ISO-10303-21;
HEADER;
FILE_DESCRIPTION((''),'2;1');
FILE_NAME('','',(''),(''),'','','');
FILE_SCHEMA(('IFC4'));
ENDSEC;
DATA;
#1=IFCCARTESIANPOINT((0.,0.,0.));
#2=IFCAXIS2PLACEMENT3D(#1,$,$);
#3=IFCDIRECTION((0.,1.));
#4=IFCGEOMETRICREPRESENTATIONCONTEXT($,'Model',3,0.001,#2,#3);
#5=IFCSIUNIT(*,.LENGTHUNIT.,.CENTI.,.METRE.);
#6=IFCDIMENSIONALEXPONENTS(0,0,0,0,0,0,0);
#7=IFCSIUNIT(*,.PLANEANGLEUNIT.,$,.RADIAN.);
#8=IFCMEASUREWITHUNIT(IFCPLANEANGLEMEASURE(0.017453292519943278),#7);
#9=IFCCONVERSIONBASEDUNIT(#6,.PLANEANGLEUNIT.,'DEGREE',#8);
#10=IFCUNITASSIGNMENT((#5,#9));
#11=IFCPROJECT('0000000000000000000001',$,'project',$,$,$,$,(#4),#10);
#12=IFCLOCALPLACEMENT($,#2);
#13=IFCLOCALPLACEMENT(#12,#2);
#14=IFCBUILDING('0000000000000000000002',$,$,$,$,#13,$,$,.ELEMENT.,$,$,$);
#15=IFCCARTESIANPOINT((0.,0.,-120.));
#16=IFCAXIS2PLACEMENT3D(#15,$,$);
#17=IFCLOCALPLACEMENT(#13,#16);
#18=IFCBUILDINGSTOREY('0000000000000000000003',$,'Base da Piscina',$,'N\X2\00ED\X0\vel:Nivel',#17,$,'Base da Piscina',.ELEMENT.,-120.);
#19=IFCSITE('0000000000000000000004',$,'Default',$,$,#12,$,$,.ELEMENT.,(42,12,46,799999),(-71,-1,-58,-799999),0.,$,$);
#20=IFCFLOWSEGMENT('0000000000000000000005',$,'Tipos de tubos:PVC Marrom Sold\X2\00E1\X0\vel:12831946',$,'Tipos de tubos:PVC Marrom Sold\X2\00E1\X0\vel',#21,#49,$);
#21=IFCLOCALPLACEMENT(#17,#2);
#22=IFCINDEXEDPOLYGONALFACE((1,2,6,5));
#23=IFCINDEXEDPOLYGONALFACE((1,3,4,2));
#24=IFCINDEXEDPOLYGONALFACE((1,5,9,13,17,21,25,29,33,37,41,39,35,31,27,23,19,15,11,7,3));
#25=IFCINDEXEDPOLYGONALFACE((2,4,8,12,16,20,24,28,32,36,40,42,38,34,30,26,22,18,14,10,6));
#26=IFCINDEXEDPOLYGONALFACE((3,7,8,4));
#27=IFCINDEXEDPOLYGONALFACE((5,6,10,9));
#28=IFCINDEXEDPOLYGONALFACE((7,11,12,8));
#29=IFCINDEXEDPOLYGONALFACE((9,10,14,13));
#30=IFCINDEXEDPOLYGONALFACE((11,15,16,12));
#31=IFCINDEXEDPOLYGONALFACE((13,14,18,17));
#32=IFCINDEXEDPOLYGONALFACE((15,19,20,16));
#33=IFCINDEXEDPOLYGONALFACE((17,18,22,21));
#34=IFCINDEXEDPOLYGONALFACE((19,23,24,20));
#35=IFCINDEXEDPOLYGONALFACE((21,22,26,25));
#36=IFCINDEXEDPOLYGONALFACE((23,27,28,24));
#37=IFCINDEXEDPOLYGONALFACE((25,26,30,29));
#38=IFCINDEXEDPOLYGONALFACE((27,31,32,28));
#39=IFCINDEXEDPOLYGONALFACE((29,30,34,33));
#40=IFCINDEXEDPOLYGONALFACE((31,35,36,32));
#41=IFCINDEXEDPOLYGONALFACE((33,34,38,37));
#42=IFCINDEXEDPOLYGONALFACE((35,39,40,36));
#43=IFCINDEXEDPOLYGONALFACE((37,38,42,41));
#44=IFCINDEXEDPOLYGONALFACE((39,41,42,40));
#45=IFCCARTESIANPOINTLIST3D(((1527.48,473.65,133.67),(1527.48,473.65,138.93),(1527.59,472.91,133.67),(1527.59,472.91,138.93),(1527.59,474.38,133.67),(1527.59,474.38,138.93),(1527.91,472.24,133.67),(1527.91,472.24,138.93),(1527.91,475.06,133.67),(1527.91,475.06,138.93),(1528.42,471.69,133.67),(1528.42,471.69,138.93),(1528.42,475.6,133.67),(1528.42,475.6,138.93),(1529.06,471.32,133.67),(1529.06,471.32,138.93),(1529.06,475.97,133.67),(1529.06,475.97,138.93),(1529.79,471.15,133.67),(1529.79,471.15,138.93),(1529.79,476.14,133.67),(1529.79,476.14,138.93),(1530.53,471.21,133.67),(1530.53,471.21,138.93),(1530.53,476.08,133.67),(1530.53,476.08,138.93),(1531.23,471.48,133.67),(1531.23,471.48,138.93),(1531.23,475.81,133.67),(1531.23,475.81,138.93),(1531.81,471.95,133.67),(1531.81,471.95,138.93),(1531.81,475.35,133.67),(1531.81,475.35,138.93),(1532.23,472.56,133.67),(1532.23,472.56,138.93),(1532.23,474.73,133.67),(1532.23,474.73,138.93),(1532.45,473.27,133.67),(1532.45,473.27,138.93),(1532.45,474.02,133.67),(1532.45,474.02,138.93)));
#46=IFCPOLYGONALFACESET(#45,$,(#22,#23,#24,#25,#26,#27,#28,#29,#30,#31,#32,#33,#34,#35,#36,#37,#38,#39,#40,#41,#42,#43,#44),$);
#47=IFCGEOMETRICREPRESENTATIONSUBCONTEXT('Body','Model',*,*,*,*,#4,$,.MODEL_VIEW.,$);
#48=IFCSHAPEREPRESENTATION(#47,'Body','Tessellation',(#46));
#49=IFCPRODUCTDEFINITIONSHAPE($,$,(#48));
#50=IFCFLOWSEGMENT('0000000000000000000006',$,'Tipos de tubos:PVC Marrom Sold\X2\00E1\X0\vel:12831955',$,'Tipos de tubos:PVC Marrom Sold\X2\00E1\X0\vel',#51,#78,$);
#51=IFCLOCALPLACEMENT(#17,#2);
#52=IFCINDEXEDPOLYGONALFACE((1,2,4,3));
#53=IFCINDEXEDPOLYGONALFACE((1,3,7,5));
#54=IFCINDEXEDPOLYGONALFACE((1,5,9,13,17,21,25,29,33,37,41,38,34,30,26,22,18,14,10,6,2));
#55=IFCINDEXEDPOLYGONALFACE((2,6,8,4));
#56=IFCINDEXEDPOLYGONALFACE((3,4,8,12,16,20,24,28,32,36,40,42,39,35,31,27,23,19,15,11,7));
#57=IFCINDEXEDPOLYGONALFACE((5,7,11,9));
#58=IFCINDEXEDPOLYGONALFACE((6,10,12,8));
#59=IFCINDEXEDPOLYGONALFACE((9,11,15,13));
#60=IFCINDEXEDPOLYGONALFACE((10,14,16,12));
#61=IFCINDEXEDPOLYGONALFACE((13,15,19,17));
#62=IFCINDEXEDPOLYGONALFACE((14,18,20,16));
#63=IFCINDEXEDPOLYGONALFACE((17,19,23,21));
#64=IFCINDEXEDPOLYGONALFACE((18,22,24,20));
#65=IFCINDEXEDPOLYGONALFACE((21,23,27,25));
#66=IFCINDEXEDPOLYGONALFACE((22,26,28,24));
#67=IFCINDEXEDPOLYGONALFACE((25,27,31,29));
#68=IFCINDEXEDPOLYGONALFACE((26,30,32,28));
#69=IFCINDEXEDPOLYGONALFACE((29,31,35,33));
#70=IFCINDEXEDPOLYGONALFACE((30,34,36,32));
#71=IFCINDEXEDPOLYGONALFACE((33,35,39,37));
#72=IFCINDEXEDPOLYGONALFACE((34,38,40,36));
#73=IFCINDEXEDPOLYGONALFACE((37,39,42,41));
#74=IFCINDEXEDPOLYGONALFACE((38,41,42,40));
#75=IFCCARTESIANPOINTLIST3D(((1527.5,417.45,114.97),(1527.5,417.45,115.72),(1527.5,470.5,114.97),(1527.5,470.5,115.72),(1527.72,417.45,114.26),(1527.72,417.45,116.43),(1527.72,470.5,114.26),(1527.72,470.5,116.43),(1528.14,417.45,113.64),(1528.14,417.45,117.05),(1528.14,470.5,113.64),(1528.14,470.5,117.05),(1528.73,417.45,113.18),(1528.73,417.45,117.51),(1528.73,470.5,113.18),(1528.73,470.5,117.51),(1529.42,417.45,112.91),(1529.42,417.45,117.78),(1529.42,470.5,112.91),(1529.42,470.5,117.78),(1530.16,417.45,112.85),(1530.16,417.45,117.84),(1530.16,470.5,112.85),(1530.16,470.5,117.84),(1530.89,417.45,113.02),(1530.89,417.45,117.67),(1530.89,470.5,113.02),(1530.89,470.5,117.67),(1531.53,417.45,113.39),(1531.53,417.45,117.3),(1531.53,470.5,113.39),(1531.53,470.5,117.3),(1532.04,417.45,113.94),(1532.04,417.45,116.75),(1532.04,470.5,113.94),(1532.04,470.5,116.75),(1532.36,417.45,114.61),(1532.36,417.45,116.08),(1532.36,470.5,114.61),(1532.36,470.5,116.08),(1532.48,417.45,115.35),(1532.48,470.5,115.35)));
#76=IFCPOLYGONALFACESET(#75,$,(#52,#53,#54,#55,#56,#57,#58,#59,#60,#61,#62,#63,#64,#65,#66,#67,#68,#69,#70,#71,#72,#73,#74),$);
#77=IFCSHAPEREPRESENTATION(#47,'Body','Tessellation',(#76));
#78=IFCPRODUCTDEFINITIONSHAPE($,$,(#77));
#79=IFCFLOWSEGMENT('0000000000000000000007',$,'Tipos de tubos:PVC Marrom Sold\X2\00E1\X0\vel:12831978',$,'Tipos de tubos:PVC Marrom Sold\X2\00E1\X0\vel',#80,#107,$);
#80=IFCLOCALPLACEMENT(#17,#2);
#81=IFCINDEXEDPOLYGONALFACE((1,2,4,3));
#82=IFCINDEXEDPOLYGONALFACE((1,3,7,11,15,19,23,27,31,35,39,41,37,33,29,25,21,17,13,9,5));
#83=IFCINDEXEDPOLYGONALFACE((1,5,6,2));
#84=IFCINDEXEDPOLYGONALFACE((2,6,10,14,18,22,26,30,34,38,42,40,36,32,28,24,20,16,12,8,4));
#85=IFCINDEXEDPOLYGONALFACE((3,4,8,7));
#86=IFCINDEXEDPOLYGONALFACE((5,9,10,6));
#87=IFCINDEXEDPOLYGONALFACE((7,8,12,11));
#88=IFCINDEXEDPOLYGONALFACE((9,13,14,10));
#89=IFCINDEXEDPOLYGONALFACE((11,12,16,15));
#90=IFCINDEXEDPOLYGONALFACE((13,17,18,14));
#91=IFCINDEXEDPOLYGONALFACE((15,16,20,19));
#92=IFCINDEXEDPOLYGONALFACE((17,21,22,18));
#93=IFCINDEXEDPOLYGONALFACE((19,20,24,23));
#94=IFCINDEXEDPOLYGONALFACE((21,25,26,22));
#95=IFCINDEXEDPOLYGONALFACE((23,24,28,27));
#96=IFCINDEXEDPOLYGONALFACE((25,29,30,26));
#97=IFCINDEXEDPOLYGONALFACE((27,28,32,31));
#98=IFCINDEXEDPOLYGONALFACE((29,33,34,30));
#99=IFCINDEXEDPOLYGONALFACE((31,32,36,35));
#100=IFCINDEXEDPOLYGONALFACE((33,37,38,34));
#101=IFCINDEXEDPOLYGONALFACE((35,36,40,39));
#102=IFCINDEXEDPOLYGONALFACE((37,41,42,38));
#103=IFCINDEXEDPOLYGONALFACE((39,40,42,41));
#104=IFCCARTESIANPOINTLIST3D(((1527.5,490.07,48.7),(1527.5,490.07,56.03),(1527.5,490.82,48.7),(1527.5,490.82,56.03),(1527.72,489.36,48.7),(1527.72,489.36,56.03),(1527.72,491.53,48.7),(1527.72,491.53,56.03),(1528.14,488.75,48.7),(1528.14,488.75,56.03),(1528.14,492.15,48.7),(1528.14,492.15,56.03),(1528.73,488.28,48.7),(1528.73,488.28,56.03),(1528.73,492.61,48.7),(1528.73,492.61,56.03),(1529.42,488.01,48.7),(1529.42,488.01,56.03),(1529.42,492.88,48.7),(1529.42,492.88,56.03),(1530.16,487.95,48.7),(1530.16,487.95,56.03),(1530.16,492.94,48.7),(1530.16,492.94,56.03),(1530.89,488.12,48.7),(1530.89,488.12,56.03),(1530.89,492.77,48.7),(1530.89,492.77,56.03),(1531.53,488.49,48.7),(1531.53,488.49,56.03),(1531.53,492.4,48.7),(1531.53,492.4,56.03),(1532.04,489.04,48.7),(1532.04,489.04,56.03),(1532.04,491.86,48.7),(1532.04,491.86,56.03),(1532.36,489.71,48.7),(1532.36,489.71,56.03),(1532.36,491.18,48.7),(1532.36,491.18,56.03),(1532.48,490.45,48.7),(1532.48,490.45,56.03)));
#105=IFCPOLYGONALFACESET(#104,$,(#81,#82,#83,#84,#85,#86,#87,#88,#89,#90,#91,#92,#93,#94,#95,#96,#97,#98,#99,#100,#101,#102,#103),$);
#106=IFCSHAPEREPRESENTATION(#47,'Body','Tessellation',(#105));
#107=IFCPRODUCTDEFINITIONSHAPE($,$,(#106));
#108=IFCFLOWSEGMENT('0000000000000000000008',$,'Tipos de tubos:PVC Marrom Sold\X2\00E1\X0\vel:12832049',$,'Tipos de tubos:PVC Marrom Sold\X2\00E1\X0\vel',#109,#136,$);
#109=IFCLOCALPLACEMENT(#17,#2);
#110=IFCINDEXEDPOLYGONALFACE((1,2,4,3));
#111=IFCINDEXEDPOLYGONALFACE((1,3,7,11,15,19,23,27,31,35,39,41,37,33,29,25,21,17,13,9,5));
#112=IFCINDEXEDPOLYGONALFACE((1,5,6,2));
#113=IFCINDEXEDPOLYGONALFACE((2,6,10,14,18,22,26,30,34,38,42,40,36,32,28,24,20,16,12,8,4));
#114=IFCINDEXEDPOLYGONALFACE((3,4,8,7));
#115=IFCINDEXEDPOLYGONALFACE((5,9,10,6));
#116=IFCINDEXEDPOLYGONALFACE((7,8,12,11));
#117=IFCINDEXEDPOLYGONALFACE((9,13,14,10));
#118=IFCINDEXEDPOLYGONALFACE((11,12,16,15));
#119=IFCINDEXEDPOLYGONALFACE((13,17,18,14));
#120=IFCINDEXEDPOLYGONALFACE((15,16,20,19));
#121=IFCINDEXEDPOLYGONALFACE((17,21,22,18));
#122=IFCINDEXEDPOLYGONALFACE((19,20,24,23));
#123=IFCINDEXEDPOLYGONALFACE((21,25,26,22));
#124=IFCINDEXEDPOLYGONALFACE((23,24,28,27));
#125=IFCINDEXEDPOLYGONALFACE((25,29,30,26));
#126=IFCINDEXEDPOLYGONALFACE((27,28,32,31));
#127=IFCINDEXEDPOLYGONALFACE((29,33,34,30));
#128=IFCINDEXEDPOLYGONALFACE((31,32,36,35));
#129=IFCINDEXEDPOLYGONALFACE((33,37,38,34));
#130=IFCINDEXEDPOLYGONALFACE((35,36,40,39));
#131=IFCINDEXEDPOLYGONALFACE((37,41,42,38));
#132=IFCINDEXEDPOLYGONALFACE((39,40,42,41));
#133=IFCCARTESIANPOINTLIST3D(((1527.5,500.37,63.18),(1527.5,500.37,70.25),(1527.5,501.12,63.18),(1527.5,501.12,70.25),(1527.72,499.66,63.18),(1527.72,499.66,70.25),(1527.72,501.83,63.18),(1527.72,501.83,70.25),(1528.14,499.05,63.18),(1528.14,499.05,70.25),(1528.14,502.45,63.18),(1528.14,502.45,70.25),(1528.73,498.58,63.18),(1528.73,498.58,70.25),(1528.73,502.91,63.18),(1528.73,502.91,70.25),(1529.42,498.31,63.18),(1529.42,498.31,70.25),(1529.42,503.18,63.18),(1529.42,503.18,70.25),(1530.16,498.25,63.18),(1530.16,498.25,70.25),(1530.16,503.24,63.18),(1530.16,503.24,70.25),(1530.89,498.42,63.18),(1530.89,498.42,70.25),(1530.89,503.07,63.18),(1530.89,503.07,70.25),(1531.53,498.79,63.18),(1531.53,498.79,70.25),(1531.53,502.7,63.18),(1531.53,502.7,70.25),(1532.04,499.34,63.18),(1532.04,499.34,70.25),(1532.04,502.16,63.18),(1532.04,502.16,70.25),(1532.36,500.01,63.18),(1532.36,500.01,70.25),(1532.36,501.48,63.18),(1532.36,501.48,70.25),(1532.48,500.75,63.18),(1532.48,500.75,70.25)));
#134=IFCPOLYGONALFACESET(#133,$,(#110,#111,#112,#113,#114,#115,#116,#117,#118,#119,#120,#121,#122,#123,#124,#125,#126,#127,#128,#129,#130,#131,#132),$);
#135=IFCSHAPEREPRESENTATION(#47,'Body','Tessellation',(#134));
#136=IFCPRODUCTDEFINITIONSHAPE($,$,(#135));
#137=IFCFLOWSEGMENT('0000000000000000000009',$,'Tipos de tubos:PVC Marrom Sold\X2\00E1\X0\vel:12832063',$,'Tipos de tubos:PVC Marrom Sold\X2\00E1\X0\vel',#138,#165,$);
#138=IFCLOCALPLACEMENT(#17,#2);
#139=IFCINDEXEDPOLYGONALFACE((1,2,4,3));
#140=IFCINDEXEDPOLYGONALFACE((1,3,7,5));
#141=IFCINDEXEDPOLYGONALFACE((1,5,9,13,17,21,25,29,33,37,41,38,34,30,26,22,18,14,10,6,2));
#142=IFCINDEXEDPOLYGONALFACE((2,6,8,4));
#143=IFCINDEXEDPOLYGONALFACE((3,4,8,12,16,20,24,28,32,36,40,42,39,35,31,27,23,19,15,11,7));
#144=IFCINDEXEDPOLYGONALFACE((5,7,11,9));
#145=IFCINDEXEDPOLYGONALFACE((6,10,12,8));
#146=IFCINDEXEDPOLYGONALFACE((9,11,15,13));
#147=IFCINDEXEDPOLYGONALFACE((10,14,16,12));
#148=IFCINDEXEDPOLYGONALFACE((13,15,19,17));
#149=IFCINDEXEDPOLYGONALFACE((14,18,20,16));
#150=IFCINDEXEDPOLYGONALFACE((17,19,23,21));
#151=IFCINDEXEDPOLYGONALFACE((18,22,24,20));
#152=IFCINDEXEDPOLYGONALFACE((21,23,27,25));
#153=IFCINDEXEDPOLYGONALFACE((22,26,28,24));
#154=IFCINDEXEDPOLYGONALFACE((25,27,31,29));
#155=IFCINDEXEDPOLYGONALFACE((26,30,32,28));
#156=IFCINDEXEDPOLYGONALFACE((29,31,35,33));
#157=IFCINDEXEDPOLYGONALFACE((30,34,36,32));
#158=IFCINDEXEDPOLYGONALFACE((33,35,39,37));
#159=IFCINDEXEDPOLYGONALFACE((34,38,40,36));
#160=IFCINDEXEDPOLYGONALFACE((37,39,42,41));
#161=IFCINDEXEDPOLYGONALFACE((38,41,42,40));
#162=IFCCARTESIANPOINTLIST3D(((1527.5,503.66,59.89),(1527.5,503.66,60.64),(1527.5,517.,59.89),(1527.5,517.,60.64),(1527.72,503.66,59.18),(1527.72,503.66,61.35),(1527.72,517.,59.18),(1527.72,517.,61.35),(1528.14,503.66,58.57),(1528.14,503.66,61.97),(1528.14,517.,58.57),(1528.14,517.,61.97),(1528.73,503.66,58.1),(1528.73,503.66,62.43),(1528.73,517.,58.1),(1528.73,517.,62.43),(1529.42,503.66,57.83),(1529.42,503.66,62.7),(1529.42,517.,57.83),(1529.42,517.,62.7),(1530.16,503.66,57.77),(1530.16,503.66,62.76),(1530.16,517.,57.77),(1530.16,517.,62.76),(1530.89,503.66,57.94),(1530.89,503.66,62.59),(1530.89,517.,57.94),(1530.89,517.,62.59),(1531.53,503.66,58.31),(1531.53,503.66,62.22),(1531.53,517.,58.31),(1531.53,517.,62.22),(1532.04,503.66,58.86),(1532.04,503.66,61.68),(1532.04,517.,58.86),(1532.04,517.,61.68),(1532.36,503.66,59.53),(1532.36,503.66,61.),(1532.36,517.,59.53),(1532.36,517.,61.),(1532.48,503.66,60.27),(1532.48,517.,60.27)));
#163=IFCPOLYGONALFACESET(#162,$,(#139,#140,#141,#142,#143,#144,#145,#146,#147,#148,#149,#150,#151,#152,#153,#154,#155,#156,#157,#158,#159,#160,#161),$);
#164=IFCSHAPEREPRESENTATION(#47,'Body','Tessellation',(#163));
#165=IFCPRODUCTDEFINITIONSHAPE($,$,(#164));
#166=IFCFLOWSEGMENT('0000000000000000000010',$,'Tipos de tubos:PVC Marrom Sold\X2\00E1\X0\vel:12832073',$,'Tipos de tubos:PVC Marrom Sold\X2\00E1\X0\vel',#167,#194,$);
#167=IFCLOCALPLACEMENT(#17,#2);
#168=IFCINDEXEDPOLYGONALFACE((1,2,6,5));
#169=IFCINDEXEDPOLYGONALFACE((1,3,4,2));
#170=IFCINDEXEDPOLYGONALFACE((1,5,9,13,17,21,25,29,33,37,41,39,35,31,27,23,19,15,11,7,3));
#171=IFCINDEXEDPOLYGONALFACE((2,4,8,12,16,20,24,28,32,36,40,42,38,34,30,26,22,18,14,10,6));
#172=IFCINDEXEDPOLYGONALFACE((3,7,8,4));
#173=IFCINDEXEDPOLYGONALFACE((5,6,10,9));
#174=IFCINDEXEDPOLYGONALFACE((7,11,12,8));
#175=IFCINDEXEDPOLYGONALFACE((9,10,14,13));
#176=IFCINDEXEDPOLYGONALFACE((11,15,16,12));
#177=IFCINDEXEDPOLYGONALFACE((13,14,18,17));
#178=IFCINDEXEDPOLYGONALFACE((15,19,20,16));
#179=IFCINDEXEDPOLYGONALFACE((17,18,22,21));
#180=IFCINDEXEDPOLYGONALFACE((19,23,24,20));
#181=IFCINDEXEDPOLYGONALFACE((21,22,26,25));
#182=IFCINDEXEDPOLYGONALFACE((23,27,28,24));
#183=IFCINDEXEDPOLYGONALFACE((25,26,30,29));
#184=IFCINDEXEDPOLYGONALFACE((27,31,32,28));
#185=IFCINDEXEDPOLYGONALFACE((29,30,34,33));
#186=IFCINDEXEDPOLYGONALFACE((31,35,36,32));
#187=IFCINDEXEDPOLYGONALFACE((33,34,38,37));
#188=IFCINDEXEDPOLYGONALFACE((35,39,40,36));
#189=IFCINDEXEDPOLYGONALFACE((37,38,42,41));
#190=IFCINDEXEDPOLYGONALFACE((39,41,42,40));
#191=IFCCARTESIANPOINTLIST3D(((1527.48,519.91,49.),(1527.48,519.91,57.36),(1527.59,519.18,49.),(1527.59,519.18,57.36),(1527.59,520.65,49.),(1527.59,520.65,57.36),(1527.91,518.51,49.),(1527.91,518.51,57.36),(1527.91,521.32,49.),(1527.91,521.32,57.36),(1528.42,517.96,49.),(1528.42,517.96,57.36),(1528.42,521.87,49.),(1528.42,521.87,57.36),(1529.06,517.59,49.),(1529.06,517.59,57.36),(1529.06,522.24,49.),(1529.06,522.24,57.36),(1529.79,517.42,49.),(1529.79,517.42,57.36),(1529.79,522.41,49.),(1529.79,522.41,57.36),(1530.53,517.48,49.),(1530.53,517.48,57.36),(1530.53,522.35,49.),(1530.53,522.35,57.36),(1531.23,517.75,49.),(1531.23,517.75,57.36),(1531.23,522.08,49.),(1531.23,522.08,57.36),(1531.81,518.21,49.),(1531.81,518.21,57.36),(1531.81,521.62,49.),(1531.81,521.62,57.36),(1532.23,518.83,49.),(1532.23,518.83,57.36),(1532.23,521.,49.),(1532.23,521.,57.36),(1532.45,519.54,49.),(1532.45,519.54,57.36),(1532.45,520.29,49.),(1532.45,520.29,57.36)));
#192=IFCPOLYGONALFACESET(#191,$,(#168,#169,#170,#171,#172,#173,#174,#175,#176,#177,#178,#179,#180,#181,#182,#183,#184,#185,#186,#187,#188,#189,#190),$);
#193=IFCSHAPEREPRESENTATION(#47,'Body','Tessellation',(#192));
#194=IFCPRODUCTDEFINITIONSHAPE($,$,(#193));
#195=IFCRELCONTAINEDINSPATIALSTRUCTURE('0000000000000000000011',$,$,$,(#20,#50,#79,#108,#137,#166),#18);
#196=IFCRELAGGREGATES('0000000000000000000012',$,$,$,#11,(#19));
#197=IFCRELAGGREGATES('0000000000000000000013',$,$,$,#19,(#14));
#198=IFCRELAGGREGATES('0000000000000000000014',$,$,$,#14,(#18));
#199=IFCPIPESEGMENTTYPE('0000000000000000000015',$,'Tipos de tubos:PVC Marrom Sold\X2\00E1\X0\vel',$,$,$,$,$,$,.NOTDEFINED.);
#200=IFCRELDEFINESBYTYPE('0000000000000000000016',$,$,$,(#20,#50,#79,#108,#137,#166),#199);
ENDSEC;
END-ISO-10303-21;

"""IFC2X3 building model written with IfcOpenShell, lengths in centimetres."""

from ifc_helpers import new_model, entity, si_unit, converted_unit, direction, frame, frame_2d, origin, origin_2d_with_axis, place, context, subcontext, project, spatial, circle, extrude, type_object, element, save


model = new_model("IFC2X3")

# Units and contexts
model_context = context("Model", 3, precision=0.001, world=origin(), true_north=direction((0.0, 1.0)))
body_context = subcontext(model_context, "Body", "Model", "MODEL_VIEW")
ifc_project = project(units=[si_unit("LENGTHUNIT", "METRE", prefix="CENTI"), converted_unit("PLANEANGLEUNIT", "DEGREE", entity("IfcPlaneAngleMeasure", 0.017453292519943278), si_unit("PLANEANGLEUNIT", "RADIAN"), dimensions=[0, 0, 0, 0, 0, 0, 0])], contexts=[model_context])

# Site, building, storey
site_placement = place(None, origin())
site = spatial("IfcSite", under=ifc_project, at=site_placement, Name="Default", CompositionType="ELEMENT", RefLatitude=(42, 12, 46, 799999), RefLongitude=(-71, -1, -58, -799999), RefElevation=0.0)
building_placement = place(site_placement, origin())
building = spatial("IfcBuilding", under=site, at=building_placement, CompositionType="ELEMENT")
storey_placement = place(building_placement, frame((0.0, 0.0, -120.0)))
storey = spatial("IfcBuildingStorey", under=building, at=storey_placement, Name="Base da Piscina", ObjectType="Nível:Nivel", LongName="Base da Piscina", CompositionType="ELEMENT", Elevation=-120.0)

# Flow segments
pipe_segment_type = type_object("IfcPipeSegmentType", Name="Tipos de tubos:PVC Marrom Soldável", PredefinedType="NOTDEFINED")
flow_segment_1_placement = place(storey_placement, origin())
element("IfcFlowSegment", 1, at=flow_segment_1_placement, inside=storey, type_object=pipe_segment_type, Name="Tipos de tubos:PVC Marrom Soldável:12831946", ObjectType="Tipos de tubos:PVC Marrom Soldável", context=body_context, shape_type="SweptSolid", body=[
    extrude(circle(Radius=2.5, at=origin_2d_with_axis()), frame((1529.98, 473.65, 133.67), z_axis=(0.0, 0.0, 1.0), x_axis=(-1.0, 0.0, 0.0)), (0.0, 0.0, 1.0), 5.25),
])
flow_segment_2_placement = place(storey_placement, origin())
element("IfcFlowSegment", 2, at=flow_segment_2_placement, inside=storey, type_object=pipe_segment_type, Name="Tipos de tubos:PVC Marrom Soldável:12831955", ObjectType="Tipos de tubos:PVC Marrom Soldável", context=body_context, shape_type="SweptSolid", body=[
    extrude(circle(Radius=2.5, at=frame_2d((0.0, 0.0), x_axis=(1.0, 0.0))), frame((1529.98, 417.45, 115.35), z_axis=(0.0, 1.0, 0.0), x_axis=(1.0, 0.0, 0.0)), (0.0, 0.0, 1.0), 53.05),
])
flow_segment_3_placement = place(storey_placement, origin())
element("IfcFlowSegment", 3, at=flow_segment_3_placement, inside=storey, type_object=pipe_segment_type, Name="Tipos de tubos:PVC Marrom Soldável:12831978", ObjectType="Tipos de tubos:PVC Marrom Soldável", context=body_context, shape_type="SweptSolid", body=[
    extrude(circle(Radius=2.5, at=frame_2d((0.0, 0.0), x_axis=(1.0, 0.0))), frame((1529.98, 490.45, 48.7)), (0.0, 0.0, 1.0), 7.34),
])
flow_segment_4_placement = place(storey_placement, origin())
element("IfcFlowSegment", 4, at=flow_segment_4_placement, inside=storey, type_object=pipe_segment_type, Name="Tipos de tubos:PVC Marrom Soldável:12832049", ObjectType="Tipos de tubos:PVC Marrom Soldável", context=body_context, shape_type="SweptSolid", body=[
    extrude(circle(Radius=2.5, at=frame_2d((0.0, 0.0), x_axis=(1.0, 0.0))), frame((1529.98, 500.75, 63.18)), (0.0, 0.0, 1.0), 7.07),
])
flow_segment_5_placement = place(storey_placement, origin())
element("IfcFlowSegment", 5, at=flow_segment_5_placement, inside=storey, type_object=pipe_segment_type, Name="Tipos de tubos:PVC Marrom Soldável:12832063", ObjectType="Tipos de tubos:PVC Marrom Soldável", context=body_context, shape_type="SweptSolid", body=[
    extrude(circle(Radius=2.5, at=origin_2d_with_axis()), frame((1529.98, 503.66, 60.27), z_axis=(0.0, 1.0, 0.0), x_axis=(1.0, 0.0, 0.0)), (0.0, 0.0, 1.0), 13.35),
])
flow_segment_6_placement = place(storey_placement, origin())
element("IfcFlowSegment", 6, at=flow_segment_6_placement, inside=storey, type_object=pipe_segment_type, Name="Tipos de tubos:PVC Marrom Soldável:12832073", ObjectType="Tipos de tubos:PVC Marrom Soldável", context=body_context, shape_type="SweptSolid", body=[
    extrude(circle(Radius=2.5, at=frame_2d((0.0, 0.0), x_axis=(1.0, 0.0))), frame((1529.98, 519.91, 49.0), z_axis=(0.0, 0.0, 1.0), x_axis=(-1.0, 0.0, 0.0)), (0.0, 0.0, 1.0), 8.36),
])

save(model, "model.ifc")
